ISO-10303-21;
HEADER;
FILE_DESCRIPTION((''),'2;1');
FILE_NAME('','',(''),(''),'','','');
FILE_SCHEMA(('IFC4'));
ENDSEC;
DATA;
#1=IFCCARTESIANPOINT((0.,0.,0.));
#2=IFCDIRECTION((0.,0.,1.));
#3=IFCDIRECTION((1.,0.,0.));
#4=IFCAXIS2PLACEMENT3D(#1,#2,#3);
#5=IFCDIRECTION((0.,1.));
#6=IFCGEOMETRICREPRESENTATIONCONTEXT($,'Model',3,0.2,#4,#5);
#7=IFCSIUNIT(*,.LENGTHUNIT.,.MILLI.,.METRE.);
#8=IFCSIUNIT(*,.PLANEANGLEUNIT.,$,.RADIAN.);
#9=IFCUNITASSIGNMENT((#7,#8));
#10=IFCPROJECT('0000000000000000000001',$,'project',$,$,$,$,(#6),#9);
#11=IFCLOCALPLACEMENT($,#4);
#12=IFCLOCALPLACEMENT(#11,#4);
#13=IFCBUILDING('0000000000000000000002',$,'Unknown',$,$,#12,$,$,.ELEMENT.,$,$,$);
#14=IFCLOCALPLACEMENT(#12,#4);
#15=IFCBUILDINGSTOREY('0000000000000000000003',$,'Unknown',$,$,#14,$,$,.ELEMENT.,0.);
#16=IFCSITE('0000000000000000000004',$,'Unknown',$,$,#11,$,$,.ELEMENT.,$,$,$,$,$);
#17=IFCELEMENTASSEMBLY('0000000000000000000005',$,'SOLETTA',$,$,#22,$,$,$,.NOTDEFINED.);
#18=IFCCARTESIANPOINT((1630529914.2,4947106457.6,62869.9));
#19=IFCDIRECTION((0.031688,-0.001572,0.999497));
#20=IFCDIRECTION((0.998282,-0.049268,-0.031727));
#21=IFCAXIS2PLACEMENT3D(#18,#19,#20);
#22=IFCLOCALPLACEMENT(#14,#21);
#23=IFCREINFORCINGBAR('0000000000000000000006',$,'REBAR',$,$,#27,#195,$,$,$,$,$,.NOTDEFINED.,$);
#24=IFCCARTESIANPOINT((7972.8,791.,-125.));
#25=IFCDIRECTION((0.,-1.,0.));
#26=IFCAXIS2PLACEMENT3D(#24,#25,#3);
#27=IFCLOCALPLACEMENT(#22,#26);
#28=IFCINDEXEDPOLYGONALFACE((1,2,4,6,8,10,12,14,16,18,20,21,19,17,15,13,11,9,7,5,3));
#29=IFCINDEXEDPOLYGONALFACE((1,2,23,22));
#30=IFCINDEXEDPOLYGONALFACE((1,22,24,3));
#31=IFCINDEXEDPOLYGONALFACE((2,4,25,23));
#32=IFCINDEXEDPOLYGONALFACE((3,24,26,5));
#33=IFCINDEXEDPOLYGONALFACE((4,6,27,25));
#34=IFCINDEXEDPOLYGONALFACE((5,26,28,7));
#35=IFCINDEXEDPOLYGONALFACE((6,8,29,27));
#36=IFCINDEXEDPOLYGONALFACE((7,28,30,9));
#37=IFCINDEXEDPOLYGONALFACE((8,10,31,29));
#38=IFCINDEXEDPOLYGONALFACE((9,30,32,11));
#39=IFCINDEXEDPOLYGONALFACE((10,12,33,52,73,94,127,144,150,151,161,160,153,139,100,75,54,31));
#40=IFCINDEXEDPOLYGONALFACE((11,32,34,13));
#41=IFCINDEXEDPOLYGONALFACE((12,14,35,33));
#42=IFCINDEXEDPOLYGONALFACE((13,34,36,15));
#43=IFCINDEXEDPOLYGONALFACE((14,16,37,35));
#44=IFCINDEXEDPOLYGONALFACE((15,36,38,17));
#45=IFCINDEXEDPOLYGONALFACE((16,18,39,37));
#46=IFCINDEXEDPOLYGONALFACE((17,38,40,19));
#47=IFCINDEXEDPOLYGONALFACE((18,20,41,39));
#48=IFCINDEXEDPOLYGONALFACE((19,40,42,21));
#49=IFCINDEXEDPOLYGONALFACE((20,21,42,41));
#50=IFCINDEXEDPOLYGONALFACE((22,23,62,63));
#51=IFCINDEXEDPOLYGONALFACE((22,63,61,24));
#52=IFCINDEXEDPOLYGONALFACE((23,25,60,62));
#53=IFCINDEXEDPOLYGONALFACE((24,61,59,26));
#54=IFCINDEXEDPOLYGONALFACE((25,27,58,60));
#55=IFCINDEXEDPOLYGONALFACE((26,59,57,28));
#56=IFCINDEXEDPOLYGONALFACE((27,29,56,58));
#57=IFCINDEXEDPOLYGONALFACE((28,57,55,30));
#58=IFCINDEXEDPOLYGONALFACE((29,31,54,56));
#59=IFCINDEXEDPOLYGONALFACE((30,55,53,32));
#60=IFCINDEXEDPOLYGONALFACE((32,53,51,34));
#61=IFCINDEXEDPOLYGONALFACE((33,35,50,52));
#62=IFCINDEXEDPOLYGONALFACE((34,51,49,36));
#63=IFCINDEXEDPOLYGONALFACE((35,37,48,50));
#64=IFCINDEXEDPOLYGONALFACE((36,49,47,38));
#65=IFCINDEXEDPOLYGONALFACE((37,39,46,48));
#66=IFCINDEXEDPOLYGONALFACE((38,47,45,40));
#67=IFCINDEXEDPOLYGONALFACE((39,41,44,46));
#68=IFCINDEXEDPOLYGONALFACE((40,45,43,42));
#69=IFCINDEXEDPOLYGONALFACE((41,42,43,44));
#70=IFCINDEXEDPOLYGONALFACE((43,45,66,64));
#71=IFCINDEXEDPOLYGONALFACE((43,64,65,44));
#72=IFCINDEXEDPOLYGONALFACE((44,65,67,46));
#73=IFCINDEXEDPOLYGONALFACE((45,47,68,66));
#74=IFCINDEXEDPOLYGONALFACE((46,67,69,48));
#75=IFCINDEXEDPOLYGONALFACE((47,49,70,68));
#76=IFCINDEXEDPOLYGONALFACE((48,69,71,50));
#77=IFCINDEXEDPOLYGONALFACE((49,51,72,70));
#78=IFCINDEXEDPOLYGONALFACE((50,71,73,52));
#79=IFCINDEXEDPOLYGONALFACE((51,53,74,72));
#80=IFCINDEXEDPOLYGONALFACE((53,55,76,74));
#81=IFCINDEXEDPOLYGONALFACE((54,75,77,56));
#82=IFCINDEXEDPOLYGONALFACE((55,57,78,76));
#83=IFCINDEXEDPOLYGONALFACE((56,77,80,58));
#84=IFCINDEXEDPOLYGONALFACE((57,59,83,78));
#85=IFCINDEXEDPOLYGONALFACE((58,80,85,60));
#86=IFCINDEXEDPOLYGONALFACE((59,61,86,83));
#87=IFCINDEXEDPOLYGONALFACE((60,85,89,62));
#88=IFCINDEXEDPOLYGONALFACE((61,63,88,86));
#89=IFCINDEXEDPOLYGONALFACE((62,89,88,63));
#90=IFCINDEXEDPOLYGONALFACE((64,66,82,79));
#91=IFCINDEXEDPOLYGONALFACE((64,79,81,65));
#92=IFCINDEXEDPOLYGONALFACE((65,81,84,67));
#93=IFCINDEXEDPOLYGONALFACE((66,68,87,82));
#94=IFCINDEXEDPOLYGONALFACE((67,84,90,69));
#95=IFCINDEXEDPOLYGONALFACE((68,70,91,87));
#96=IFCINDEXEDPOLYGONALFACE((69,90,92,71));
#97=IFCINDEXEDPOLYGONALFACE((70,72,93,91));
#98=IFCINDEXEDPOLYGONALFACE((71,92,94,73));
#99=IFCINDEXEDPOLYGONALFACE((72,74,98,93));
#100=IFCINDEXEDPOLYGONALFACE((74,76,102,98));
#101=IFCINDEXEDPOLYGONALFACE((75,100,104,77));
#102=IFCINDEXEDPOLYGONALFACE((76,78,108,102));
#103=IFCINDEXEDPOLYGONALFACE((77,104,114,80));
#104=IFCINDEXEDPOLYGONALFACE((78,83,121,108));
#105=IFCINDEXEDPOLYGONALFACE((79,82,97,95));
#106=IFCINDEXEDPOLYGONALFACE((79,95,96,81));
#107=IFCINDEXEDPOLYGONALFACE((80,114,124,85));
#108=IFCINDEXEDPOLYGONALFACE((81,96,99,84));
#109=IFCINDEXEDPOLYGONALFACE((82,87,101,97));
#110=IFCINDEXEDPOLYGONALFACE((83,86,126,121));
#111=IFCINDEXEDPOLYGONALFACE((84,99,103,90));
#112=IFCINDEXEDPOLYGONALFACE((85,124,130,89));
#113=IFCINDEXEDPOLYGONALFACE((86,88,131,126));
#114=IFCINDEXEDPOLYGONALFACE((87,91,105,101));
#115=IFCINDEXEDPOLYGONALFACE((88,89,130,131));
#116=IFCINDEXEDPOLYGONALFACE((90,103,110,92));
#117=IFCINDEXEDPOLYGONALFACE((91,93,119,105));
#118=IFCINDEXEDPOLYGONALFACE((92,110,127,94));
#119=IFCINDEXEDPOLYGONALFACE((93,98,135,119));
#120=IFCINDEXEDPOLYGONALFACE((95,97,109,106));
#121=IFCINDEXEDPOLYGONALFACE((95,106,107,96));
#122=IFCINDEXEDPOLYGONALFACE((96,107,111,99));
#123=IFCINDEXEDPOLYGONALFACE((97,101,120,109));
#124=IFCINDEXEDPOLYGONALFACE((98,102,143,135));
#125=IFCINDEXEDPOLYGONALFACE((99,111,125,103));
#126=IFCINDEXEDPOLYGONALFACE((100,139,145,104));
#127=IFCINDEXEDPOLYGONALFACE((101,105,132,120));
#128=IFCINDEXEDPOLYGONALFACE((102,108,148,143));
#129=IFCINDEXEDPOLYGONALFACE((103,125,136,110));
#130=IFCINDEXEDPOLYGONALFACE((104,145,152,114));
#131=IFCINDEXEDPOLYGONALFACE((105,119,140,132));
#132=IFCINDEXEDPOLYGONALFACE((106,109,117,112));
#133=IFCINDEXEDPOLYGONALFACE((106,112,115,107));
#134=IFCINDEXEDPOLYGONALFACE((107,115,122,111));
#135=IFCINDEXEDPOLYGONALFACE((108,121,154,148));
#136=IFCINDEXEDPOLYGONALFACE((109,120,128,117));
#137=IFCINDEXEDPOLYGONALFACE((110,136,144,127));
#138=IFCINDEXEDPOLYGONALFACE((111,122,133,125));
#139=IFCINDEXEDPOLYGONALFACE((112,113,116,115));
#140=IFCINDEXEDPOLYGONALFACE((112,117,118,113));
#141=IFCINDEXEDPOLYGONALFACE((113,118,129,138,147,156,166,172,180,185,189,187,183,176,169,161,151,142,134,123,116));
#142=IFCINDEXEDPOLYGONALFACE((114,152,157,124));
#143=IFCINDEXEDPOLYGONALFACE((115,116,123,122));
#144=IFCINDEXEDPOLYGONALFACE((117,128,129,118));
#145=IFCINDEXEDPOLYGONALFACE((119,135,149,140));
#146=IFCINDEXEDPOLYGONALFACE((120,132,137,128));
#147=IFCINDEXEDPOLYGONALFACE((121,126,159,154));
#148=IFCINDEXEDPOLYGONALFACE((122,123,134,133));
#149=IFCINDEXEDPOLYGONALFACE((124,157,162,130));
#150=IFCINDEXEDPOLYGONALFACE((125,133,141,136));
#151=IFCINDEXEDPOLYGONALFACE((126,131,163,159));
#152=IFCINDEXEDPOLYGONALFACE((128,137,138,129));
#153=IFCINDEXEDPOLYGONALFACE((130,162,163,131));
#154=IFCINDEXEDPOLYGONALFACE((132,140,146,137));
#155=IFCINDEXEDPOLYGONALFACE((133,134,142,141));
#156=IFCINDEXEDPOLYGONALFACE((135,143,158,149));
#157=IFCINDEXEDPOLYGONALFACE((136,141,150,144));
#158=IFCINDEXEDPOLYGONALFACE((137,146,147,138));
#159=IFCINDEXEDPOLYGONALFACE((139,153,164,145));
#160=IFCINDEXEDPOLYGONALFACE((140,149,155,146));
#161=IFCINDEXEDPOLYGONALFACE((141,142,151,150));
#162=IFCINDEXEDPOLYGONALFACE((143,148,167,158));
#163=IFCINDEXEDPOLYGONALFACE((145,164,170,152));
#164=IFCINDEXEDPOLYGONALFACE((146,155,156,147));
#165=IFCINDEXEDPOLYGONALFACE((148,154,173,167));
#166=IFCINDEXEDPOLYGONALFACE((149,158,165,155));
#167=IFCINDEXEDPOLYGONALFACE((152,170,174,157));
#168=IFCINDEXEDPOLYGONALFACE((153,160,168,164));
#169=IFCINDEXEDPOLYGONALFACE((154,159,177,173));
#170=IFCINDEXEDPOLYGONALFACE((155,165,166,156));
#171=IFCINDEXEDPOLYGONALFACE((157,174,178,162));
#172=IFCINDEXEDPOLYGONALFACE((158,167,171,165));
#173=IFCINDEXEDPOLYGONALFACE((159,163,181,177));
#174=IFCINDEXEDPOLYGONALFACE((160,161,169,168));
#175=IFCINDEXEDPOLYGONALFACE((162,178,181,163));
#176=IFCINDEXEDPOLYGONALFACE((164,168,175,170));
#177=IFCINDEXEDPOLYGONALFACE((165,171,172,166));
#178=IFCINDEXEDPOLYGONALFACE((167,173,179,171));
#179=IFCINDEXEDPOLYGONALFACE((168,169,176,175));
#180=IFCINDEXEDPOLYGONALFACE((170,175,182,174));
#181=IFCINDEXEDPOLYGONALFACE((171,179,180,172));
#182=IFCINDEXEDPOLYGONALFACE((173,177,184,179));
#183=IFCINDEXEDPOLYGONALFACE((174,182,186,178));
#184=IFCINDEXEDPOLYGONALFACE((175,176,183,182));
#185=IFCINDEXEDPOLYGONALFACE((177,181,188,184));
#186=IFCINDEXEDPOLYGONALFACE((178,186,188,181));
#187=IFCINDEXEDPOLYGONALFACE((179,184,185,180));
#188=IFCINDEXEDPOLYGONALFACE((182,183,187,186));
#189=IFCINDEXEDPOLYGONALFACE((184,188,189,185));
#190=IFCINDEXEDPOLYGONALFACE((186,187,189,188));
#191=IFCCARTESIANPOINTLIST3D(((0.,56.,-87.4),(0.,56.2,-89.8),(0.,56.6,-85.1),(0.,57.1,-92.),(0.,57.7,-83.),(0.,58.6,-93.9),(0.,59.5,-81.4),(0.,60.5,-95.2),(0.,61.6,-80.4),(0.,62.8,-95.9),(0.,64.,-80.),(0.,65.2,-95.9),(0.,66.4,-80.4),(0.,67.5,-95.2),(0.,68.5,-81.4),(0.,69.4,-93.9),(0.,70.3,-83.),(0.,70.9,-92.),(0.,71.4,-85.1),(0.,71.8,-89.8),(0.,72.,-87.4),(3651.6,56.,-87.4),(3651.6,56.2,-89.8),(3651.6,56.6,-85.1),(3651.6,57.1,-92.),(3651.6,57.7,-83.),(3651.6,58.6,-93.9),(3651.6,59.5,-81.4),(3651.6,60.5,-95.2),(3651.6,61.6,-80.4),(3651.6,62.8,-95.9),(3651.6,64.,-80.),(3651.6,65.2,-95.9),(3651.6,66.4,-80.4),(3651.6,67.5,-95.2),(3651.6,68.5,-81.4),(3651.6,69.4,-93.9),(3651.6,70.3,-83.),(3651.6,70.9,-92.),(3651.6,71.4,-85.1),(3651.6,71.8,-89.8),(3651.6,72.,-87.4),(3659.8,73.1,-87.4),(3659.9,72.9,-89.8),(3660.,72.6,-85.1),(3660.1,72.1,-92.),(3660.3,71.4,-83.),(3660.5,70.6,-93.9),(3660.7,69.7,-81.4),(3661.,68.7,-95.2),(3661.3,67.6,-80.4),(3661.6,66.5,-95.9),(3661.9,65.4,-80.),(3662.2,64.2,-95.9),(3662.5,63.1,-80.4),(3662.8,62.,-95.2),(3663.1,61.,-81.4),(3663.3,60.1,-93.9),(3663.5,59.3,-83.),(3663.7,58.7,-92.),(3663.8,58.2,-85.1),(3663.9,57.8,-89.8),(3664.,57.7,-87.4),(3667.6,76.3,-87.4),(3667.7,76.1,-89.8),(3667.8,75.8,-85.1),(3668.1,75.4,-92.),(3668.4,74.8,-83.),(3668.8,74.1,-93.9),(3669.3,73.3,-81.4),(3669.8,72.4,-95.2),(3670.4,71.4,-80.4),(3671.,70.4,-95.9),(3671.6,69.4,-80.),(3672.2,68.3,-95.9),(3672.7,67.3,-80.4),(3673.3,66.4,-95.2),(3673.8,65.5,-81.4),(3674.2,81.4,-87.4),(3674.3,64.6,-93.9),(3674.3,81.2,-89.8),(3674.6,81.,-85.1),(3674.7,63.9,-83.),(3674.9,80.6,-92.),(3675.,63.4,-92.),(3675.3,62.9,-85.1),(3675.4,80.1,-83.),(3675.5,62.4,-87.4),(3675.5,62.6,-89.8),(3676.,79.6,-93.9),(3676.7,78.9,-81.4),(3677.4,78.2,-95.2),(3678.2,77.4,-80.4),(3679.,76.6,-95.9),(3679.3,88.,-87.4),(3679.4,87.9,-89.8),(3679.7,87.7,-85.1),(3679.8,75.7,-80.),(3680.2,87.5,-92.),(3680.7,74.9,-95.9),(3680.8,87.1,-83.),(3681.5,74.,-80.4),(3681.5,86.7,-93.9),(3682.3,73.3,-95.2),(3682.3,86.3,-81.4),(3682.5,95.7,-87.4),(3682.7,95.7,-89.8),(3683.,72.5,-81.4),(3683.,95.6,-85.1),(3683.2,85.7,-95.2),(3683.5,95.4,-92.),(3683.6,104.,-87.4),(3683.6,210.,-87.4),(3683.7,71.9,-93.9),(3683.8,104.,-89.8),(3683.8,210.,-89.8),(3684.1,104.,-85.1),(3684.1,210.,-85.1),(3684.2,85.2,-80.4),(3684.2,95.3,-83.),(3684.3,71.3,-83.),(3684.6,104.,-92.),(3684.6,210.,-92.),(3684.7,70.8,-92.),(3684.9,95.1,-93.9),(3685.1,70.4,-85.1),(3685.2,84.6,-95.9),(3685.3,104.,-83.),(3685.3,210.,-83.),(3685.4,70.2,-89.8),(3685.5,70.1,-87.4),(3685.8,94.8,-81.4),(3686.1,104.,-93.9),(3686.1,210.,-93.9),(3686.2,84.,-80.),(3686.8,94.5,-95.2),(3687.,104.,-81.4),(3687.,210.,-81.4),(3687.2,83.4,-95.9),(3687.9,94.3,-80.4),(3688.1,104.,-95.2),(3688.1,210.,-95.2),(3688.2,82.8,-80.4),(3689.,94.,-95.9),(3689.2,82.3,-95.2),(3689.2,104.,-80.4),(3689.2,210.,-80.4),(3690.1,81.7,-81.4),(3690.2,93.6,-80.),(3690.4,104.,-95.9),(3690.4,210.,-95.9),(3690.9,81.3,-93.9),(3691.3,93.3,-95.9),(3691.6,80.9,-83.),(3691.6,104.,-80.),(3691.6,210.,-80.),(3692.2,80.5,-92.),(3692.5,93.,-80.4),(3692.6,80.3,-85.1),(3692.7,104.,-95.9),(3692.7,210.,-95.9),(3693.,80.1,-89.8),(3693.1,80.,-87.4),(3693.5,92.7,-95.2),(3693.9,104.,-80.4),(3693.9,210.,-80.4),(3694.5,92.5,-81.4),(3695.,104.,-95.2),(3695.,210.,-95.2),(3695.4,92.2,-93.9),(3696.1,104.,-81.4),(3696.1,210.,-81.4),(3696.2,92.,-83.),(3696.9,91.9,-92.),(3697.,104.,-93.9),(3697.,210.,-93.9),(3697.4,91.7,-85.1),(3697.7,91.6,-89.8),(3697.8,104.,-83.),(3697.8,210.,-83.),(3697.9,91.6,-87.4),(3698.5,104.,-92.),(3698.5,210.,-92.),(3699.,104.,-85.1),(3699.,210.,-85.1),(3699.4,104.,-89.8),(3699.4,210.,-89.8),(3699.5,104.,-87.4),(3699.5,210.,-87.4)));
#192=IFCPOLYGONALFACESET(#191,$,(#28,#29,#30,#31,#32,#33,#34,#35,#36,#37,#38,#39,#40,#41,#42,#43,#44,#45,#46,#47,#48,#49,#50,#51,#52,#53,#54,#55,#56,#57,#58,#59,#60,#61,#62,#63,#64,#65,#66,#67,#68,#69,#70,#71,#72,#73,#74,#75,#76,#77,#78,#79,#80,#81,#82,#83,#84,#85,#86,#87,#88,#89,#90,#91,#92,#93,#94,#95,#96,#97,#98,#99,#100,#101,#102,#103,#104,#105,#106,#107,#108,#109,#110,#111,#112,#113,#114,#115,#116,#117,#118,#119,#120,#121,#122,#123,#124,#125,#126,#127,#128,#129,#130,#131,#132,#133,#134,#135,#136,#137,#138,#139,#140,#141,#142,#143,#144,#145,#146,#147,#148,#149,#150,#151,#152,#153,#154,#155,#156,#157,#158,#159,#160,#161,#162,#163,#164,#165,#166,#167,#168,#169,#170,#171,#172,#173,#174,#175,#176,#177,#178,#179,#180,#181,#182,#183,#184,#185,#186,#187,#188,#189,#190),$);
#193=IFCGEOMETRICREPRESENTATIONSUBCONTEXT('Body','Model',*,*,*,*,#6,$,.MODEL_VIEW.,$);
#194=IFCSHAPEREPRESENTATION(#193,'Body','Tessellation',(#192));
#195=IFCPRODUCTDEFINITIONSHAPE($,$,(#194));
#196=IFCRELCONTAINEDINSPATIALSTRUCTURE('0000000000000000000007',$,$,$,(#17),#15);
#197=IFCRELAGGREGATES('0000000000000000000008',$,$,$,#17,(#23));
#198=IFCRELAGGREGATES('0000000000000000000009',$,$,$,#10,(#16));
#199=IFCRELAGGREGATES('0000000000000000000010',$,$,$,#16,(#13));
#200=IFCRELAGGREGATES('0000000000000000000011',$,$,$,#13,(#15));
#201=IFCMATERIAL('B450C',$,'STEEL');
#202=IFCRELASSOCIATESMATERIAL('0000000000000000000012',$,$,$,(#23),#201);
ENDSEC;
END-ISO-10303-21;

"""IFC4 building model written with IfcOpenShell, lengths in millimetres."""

from ifc_helpers import new_model, entity, si_unit, direction, frame, origin_with_axes, place, context, subcontext, project, spatial, material, element, aggregate, save


model = new_model("IFC4")

# Units and contexts
model_context = context("Model", 3, precision=0.2, world=origin_with_axes(), true_north=direction((0.0, 1.0)))
body_context = subcontext(model_context, "Body", "Model", "MODEL_VIEW")
ifc_project = project(units=[si_unit("LENGTHUNIT", "METRE", prefix="MILLI"), si_unit("PLANEANGLEUNIT", "RADIAN")], contexts=[model_context])

# Site, building, storey
site_placement = place(None, origin_with_axes())
site = spatial("IfcSite", under=ifc_project, at=site_placement, Name="Unknown", CompositionType="ELEMENT")
building_placement = place(site_placement, origin_with_axes())
building = spatial("IfcBuilding", under=site, at=building_placement, Name="Unknown", CompositionType="ELEMENT")
storey_placement = place(building_placement, origin_with_axes())
storey = spatial("IfcBuildingStorey", under=building, at=storey_placement, Name="Unknown", CompositionType="ELEMENT", Elevation=0.0)

# Element assembly, reinforcing bar
ifc_material = material(Name="B450C", Category="STEEL")
assembly_1_placement = place(storey_placement, frame((1630529914.2, 4947106457.6, 62869.9), z_axis=(0.031688, -0.001572, 0.999497), x_axis=(0.998282, -0.049268, -0.031727)))
assembly_1 = element("IfcElementAssembly", 1, at=assembly_1_placement, inside=storey, Name="SOLETTA", PredefinedType="NOTDEFINED")
reinforcing_bar_1_placement = place(assembly_1_placement, frame((7972.8, 791.0, -125.0), z_axis=(0.0, -1.0, 0.0), x_axis=(1.0, 0.0, 0.0)))
reinforcing_bar_1 = element("IfcReinforcingBar", 2, at=reinforcing_bar_1_placement, material=ifc_material, Name="REBAR", PredefinedType="NOTDEFINED", context=body_context, shape_type="AdvancedSweptSolid", body=[
    entity("IfcSweptDiskSolid", entity("IfcIndexedPolyCurve", entity("IfcCartesianPointList3D", [[0.0, 64.0, -88.0], [3651.6, 64.0, -88.0], [3679.8, 75.7, -88.0], [3691.6, 104.0, -88.0], [3691.6, 210.0, -88.0]]), [entity("IfcLineIndex", [1, 2]), entity("IfcArcIndex", [2, 3, 4]), entity("IfcLineIndex", [4, 5])]), 8.0),
])
aggregate(assembly_1, [reinforcing_bar_1])

save(model, "model.ifc")
